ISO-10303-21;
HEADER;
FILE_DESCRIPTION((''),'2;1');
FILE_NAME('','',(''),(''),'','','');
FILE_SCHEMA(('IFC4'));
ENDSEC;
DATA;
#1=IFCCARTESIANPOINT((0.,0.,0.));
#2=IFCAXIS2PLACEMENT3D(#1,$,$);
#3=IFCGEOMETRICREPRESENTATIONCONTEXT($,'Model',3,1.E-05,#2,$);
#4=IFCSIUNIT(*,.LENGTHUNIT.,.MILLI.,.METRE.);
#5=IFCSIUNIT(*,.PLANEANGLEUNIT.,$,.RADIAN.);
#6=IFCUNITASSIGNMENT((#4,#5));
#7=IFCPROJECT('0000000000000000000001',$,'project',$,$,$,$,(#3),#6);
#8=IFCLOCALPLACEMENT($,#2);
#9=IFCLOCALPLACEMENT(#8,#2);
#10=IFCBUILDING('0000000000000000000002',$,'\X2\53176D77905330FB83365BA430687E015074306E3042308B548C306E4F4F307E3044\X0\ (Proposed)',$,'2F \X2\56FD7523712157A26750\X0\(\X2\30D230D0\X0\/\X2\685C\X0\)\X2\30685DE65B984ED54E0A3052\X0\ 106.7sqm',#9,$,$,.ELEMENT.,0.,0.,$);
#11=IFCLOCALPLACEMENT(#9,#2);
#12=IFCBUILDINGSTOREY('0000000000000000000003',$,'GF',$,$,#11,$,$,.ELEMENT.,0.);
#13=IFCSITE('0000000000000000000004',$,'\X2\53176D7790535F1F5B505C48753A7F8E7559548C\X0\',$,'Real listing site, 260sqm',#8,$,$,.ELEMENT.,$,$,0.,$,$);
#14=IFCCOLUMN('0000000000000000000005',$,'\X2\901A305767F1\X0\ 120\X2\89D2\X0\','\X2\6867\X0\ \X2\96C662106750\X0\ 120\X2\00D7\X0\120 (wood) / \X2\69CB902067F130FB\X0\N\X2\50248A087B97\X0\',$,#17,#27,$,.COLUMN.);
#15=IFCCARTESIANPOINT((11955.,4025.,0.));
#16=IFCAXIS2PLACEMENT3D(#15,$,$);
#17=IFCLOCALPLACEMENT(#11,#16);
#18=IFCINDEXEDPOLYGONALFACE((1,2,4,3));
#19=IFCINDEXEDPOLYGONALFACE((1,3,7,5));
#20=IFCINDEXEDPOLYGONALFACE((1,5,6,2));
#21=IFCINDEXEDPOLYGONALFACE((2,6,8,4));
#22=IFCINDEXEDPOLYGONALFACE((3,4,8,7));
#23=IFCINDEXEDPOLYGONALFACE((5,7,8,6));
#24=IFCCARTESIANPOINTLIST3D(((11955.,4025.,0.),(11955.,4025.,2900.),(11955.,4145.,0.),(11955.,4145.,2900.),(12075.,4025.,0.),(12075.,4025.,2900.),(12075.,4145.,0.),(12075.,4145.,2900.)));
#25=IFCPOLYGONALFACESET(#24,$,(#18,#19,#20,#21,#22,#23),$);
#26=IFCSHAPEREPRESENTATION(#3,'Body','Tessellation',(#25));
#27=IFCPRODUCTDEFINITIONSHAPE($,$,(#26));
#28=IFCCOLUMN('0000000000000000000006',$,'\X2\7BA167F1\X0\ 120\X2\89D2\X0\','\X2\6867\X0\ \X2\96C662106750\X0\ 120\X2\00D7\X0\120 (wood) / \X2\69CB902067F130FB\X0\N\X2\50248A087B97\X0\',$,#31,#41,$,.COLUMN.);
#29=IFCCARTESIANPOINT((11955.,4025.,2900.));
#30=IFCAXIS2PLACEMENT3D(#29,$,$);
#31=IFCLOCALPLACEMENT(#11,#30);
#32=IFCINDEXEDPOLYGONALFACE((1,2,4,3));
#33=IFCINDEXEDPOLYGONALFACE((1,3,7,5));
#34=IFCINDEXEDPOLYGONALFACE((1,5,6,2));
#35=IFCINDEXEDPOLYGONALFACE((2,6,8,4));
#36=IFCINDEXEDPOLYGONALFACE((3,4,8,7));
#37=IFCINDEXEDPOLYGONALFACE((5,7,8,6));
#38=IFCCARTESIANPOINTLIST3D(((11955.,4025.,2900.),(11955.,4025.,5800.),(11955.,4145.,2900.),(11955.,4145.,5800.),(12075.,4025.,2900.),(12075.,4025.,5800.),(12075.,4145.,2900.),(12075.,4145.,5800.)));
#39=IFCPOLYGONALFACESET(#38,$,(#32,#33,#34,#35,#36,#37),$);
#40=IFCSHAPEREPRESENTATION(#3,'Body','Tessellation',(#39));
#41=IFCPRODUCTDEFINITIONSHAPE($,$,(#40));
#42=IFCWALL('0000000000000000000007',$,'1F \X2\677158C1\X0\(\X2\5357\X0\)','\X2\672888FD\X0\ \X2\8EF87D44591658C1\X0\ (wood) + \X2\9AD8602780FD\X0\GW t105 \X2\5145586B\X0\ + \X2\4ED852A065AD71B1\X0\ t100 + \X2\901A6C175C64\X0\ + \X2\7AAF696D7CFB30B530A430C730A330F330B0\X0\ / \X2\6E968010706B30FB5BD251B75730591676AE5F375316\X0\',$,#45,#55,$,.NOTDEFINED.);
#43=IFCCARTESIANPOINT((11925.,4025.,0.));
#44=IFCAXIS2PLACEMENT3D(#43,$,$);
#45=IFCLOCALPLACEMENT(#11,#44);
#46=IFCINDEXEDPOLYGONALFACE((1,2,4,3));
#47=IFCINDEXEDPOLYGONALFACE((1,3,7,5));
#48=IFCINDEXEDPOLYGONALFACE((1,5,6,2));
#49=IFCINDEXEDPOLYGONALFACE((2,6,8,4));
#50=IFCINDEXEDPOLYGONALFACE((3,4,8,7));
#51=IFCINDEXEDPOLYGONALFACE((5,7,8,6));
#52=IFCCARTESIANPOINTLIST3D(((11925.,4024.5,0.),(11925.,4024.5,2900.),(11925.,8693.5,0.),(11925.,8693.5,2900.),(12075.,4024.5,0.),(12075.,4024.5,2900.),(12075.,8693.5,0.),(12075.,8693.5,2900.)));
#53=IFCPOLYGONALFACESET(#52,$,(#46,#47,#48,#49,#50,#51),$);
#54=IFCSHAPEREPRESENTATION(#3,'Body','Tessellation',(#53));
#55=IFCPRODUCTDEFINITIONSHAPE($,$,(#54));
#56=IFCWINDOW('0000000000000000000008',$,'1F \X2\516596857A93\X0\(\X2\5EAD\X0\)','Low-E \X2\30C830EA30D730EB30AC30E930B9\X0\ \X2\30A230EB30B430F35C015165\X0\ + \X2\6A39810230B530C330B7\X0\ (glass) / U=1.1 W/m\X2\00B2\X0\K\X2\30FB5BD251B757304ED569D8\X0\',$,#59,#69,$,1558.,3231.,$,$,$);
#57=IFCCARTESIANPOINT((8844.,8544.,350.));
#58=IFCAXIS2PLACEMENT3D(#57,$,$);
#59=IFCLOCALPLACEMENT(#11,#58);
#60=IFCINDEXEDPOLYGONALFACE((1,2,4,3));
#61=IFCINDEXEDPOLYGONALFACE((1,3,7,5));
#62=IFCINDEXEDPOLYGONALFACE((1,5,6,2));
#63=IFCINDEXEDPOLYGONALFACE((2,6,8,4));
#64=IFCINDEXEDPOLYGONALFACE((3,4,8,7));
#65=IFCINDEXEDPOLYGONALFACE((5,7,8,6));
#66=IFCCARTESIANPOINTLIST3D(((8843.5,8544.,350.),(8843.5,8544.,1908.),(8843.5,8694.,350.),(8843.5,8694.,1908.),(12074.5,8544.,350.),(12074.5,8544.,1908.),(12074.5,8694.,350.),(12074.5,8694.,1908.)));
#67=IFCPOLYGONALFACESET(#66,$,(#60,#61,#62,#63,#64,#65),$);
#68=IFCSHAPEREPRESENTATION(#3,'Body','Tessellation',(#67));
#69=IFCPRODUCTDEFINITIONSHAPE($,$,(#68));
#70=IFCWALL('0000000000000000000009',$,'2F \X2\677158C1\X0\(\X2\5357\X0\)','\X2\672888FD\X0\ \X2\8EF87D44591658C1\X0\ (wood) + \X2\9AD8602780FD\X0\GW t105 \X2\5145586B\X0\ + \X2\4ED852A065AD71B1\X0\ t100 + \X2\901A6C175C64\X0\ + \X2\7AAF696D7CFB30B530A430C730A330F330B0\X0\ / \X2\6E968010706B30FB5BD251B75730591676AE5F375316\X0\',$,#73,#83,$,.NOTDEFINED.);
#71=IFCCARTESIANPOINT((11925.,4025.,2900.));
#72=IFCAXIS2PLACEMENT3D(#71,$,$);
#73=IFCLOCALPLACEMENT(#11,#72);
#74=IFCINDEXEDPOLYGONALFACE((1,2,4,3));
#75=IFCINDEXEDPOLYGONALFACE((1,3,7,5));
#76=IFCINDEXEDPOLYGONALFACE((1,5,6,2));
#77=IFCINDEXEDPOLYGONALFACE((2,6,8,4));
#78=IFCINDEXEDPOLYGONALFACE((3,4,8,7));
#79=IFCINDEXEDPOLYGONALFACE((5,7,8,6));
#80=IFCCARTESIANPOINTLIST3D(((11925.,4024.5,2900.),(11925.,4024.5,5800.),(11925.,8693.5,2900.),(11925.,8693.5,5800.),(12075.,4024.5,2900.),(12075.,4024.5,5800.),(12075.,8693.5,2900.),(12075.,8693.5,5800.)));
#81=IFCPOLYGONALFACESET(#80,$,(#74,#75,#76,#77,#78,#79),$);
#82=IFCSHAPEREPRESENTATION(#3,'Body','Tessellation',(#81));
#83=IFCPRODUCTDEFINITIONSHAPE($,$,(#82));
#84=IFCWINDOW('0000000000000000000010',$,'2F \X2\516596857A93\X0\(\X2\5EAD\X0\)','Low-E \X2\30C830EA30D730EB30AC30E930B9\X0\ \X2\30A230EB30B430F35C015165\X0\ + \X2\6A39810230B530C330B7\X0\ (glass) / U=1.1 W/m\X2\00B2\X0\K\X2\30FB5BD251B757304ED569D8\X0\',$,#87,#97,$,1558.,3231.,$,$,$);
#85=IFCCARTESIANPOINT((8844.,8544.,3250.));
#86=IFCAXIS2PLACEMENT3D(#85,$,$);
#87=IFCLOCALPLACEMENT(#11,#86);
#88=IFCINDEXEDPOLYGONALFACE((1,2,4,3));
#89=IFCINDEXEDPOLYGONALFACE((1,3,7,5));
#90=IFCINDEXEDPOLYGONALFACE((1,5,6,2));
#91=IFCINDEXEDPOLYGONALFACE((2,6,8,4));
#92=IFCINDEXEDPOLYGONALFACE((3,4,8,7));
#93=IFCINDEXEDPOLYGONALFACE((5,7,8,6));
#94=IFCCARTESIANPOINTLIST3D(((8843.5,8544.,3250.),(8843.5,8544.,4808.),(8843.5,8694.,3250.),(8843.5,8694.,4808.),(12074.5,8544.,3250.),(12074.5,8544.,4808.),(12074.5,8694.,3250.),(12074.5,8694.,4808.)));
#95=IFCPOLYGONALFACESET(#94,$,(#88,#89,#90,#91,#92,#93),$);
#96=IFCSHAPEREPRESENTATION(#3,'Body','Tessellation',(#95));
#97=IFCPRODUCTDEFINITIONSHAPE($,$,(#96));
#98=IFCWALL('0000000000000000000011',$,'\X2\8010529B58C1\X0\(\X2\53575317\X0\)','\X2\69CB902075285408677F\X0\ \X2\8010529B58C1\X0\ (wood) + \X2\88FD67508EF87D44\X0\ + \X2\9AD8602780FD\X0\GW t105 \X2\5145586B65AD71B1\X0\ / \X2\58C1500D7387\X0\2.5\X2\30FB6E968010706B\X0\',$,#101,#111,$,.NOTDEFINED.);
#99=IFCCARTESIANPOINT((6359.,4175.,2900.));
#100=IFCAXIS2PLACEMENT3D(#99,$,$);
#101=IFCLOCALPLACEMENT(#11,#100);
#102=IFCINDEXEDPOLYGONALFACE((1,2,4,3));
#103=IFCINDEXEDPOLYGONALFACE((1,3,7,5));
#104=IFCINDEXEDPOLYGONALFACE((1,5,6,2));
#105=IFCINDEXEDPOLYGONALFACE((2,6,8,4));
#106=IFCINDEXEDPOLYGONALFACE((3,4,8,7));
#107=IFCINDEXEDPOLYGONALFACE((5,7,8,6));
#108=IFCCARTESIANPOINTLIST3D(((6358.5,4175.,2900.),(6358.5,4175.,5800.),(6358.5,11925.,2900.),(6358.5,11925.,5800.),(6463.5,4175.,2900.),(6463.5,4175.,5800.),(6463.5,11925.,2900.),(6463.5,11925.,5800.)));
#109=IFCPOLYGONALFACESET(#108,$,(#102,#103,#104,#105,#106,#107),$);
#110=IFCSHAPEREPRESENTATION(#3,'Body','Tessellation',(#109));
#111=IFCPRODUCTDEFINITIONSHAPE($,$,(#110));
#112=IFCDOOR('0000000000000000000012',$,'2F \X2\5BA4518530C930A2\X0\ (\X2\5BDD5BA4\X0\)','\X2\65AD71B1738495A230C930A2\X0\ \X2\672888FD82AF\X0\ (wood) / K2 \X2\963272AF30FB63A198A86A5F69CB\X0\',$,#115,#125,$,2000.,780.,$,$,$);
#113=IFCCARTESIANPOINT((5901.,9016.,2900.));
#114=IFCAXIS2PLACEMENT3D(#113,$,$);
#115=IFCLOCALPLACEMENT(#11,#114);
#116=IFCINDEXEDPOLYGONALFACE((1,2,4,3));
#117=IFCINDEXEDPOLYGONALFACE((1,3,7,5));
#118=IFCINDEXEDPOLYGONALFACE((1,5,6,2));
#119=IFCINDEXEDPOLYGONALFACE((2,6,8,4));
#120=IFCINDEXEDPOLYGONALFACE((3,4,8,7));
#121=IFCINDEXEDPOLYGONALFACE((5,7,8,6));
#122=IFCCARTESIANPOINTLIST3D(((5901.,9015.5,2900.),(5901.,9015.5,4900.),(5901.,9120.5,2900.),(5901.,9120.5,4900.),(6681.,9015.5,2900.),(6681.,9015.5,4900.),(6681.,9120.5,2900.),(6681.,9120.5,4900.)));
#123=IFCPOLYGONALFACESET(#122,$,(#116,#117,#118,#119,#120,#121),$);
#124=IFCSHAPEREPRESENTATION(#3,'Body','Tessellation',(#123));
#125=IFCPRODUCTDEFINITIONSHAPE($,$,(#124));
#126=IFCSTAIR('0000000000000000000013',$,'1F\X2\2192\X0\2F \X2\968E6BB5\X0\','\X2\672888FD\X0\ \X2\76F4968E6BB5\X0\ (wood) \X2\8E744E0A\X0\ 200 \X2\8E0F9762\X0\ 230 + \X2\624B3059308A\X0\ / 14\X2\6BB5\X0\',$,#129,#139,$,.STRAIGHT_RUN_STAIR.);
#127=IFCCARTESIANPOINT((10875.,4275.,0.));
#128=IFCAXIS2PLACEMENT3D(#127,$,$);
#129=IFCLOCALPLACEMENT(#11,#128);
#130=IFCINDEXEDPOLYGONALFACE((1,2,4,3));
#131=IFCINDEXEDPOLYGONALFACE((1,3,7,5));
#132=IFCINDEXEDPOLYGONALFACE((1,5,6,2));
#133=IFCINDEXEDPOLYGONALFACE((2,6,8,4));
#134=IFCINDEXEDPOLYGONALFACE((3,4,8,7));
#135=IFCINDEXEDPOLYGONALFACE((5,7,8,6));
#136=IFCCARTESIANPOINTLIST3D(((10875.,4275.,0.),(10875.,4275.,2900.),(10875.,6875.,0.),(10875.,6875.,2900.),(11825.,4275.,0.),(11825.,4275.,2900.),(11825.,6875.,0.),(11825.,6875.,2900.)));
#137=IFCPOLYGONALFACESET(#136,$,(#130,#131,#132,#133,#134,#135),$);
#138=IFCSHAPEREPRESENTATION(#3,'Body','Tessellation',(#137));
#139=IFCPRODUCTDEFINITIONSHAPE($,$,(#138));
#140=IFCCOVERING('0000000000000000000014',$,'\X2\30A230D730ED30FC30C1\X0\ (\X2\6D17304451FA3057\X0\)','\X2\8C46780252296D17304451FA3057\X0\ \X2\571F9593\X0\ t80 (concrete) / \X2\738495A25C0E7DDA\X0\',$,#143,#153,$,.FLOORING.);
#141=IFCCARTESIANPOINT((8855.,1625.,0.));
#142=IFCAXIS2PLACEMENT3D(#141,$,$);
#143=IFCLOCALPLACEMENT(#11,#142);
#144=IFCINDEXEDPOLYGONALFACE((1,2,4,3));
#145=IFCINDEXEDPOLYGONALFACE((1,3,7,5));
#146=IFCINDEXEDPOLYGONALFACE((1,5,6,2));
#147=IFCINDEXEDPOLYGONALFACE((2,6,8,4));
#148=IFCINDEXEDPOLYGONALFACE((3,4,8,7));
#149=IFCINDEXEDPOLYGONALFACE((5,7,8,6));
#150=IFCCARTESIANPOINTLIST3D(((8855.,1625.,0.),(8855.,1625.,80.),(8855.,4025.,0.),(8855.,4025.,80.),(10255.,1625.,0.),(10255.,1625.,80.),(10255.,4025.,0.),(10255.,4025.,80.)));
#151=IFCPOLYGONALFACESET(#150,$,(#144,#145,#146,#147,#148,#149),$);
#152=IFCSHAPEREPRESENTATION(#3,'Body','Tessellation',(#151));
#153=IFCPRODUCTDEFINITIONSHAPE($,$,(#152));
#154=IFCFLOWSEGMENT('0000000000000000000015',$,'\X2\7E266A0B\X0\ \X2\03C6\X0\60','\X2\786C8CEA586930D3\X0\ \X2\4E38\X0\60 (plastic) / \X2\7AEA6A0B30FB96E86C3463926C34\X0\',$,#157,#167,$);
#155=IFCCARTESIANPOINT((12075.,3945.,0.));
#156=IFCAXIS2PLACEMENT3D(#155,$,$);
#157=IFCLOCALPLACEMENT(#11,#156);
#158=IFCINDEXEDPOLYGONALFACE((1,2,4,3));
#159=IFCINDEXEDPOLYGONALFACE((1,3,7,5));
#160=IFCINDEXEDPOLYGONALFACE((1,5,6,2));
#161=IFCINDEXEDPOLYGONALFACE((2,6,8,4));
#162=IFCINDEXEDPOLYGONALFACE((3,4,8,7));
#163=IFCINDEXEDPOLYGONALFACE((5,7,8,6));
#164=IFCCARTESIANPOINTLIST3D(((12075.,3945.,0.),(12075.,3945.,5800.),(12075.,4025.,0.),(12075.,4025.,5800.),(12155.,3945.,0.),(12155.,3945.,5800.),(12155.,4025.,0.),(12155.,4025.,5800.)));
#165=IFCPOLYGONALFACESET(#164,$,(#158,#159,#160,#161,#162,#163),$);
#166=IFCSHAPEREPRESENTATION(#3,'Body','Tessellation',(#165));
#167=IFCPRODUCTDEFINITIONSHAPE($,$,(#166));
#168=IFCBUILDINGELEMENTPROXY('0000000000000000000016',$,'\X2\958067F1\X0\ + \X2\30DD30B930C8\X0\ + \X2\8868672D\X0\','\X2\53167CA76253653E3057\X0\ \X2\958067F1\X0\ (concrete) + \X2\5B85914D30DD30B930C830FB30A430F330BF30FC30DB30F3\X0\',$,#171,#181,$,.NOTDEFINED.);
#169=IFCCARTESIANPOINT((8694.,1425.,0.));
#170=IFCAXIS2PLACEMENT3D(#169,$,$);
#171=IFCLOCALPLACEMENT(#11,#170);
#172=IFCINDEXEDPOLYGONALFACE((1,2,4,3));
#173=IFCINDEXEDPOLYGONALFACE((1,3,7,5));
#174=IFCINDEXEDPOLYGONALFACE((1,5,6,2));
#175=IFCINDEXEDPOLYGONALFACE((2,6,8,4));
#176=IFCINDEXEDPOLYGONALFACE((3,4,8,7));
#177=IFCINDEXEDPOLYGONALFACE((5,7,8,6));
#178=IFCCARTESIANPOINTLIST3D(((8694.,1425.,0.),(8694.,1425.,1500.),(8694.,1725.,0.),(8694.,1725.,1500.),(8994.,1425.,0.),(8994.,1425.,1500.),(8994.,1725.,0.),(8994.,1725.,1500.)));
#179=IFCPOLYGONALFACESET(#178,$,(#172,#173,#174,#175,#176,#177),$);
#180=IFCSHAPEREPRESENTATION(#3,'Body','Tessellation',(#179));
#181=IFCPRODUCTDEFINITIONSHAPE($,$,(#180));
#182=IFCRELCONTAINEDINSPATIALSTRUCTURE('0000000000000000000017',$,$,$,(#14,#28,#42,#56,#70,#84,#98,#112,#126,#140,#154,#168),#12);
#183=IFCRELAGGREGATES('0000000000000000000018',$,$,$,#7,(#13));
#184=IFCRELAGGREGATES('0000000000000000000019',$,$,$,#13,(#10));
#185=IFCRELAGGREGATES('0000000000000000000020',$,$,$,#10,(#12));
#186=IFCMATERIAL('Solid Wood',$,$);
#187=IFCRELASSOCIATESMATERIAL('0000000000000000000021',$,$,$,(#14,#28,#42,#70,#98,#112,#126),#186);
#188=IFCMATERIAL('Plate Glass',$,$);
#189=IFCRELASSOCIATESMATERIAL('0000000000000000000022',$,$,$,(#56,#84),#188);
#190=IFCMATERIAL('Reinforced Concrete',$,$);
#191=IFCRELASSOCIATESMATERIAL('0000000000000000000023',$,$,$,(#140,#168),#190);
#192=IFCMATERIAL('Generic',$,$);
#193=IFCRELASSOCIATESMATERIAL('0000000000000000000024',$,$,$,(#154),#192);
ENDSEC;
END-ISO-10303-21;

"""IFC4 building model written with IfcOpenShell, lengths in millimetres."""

from ifc_helpers import new_model, si_unit, frame, frame_2d, origin, place, context, project, spatial, rectangle, extrude, material, element, fill, save


model = new_model("IFC4")

# Units and contexts
model_context = context("Model", 3, precision=1e-05, world=origin())
ifc_project = project(units=[si_unit("LENGTHUNIT", "METRE", prefix="MILLI"), si_unit("PLANEANGLEUNIT", "RADIAN")], contexts=[model_context])

# Site, building, storey
site_placement = place(None, origin())
site = spatial("IfcSite", under=ifc_project, at=site_placement, Name="北海道弟子屈町美留和", ObjectType="Real listing site, 260sqm", CompositionType="ELEMENT", RefElevation=0.0)
building_placement = place(site_placement, origin())
building = spatial("IfcBuilding", under=site, at=building_placement, Name="北海道・茶室と縁側のある和の住まい (Proposed)", ObjectType="2F 国産無垢材(ヒバ/桜)と左官仕上げ 106.7sqm", CompositionType="ELEMENT", ElevationOfRefHeight=0.0, ElevationOfTerrain=0.0)
storey_placement = place(building_placement, origin())
storey = spatial("IfcBuildingStorey", under=building, at=storey_placement, Name="GF", CompositionType="ELEMENT", Elevation=0.0)

# Columns
ifc_material_1 = material(Name="Solid Wood")
column_1_placement = place(storey_placement, frame((11955.0, 4025.0, 0.0)))
element("IfcColumn", 1, at=column_1_placement, inside=storey, material=ifc_material_1, Name="通し柱 120角", Description="桧 集成材 120×120 (wood) / 構造柱・N値計算", PredefinedType="COLUMN", context=model_context, shape_type="SweptSolid", body=[
    extrude(rectangle(XDim=120.0, YDim=120.0, at=frame_2d((60.0, 60.0))), frame((11955.0, 4025.0, 0.0)), (0.0, 0.0, 1.0), 2900.0),
])
column_2_placement = place(storey_placement, frame((11955.0, 4025.0, 2900.0)))
element("IfcColumn", 2, at=column_2_placement, inside=storey, material=ifc_material_1, Name="管柱 120角", Description="桧 集成材 120×120 (wood) / 構造柱・N値計算", PredefinedType="COLUMN", context=model_context, shape_type="SweptSolid", body=[
    extrude(rectangle(XDim=120.0, YDim=120.0, at=frame_2d((60.0, 60.0))), frame((11955.0, 4025.0, 2900.0)), (0.0, 0.0, 1.0), 2900.0),
])

# Wall, opening, window
wall_1_placement = place(storey_placement, frame((11925.0, 4025.0, 0.0)))
wall_1 = element("IfcWall", 3, at=wall_1_placement, inside=storey, material=ifc_material_1, Name="1F 東壁(南)", Description="木製 軸組外壁 (wood) + 高性能GW t105 充填 + 付加断熱 t100 + 通気層 + 窯業系サイディング / 準耐火・寒冷地外皮強化", PredefinedType="NOTDEFINED", context=model_context, shape_type="SweptSolid", body=[
    extrude(rectangle(XDim=150.0, YDim=4669.0, at=frame_2d((75.0, 2334.0))), frame((11925.0, 4025.0, 0.0)), (0.0, 0.0, 1.0), 2900.0),
])
opening_1_placement = place(storey_placement, frame((8844.0, 8544.0, 350.0)))
opening_1 = element("IfcOpeningElement", 4, at=opening_1_placement, cuts=wall_1, PredefinedType="NOTDEFINED", context=model_context, shape_type="SweptSolid", body=[
    extrude(rectangle(XDim=3231.0, YDim=150.0, at=frame_2d((1615.0, 75.0))), frame((8844.0, 8544.0, 350.0)), (0.0, 0.0, 1.0), 1558.0),
])
ifc_material_2 = material(Name="Plate Glass")
window_1_placement = place(storey_placement, frame((8844.0, 8544.0, 350.0)))
window_1 = element("IfcWindow", 5, at=window_1_placement, inside=storey, material=ifc_material_2, Name="1F 入隅窓(庭)", Description="Low-E トリプルガラス アルゴン封入 + 樹脂サッシ (glass) / U=1.1 W/m²K・寒冷地仕様", OverallHeight=1558.0, OverallWidth=3231.0, context=model_context, shape_type="SweptSolid", body=[
    extrude(rectangle(XDim=3231.0, YDim=150.0, at=frame_2d((1615.0, 75.0))), frame((8844.0, 8544.0, 350.0)), (0.0, 0.0, 1.0), 1558.0),
])
fill(opening_1, window_1)

# Wall, opening, window
wall_2_placement = place(storey_placement, frame((11925.0, 4025.0, 2900.0)))
wall_2 = element("IfcWall", 6, at=wall_2_placement, inside=storey, material=ifc_material_1, Name="2F 東壁(南)", Description="木製 軸組外壁 (wood) + 高性能GW t105 充填 + 付加断熱 t100 + 通気層 + 窯業系サイディング / 準耐火・寒冷地外皮強化", PredefinedType="NOTDEFINED", context=model_context, shape_type="SweptSolid", body=[
    extrude(rectangle(XDim=150.0, YDim=4669.0, at=frame_2d((75.0, 2334.0))), frame((11925.0, 4025.0, 2900.0)), (0.0, 0.0, 1.0), 2900.0),
])
opening_2_placement = place(storey_placement, frame((8844.0, 8544.0, 3250.0)))
opening_2 = element("IfcOpeningElement", 7, at=opening_2_placement, cuts=wall_2, PredefinedType="NOTDEFINED", context=model_context, shape_type="SweptSolid", body=[
    extrude(rectangle(XDim=3231.0, YDim=150.0, at=frame_2d((1615.0, 75.0))), frame((8844.0, 8544.0, 3250.0)), (0.0, 0.0, 1.0), 1558.0),
])
window_2_placement = place(storey_placement, frame((8844.0, 8544.0, 3250.0)))
window_2 = element("IfcWindow", 8, at=window_2_placement, inside=storey, material=ifc_material_2, Name="2F 入隅窓(庭)", Description="Low-E トリプルガラス アルゴン封入 + 樹脂サッシ (glass) / U=1.1 W/m²K・寒冷地仕様", OverallHeight=1558.0, OverallWidth=3231.0, context=model_context, shape_type="SweptSolid", body=[
    extrude(rectangle(XDim=3231.0, YDim=150.0, at=frame_2d((1615.0, 75.0))), frame((8844.0, 8544.0, 3250.0)), (0.0, 0.0, 1.0), 1558.0),
])
fill(opening_2, window_2)

# Wall, opening, door
wall_3_placement = place(storey_placement, frame((6359.0, 4175.0, 2900.0)))
wall_3 = element("IfcWall", 9, at=wall_3_placement, inside=storey, material=ifc_material_1, Name="耐力壁(南北)", Description="構造用合板 耐力壁 (wood) + 製材軸組 + 高性能GW t105 充填断熱 / 壁倍率2.5・準耐火", PredefinedType="NOTDEFINED", context=model_context, shape_type="SweptSolid", body=[
    extrude(rectangle(XDim=105.0, YDim=7750.0, at=frame_2d((52.0, 3875.0))), frame((6359.0, 4175.0, 2900.0)), (0.0, 0.0, 1.0), 2900.0),
])
opening_3_placement = place(storey_placement, frame((5901.0, 9016.0, 2900.0)))
opening_3 = element("IfcOpeningElement", 10, at=opening_3_placement, cuts=wall_3, PredefinedType="NOTDEFINED", context=model_context, shape_type="SweptSolid", body=[
    extrude(rectangle(XDim=780.0, YDim=105.0, at=frame_2d((390.0, 52.0))), frame((5901.0, 9016.0, 2900.0)), (0.0, 0.0, 1.0), 2000.0),
])
door_placement = place(storey_placement, frame((5901.0, 9016.0, 2900.0)))
door = element("IfcDoor", 11, at=door_placement, inside=storey, material=ifc_material_1, Name="2F 室内ドア (寝室)", Description="断熱玄関ドア 木製芯 (wood) / K2 防犯・採風機構", OverallHeight=2000.0, OverallWidth=780.0, context=model_context, shape_type="SweptSolid", body=[
    extrude(rectangle(XDim=780.0, YDim=105.0, at=frame_2d((390.0, 52.0))), frame((5901.0, 9016.0, 2900.0)), (0.0, 0.0, 1.0), 2000.0),
])
fill(opening_3, door)

# Stair
stair_placement = place(storey_placement, frame((10875.0, 4275.0, 0.0)))
element("IfcStair", 12, at=stair_placement, inside=storey, material=ifc_material_1, Name="1F→2F 階段", Description="木製 直階段 (wood) 蹴上 200 踏面 230 + 手すり / 14段", PredefinedType="STRAIGHT_RUN_STAIR", context=model_context, shape_type="SweptSolid", body=[
    extrude(rectangle(XDim=950.0, YDim=2600.0, at=frame_2d((475.0, 1300.0))), frame((10875.0, 4275.0, 0.0)), (0.0, 0.0, 1.0), 2900.0),
])

# Covering
ifc_material_3 = material(Name="Reinforced Concrete")
covering_placement = place(storey_placement, frame((8855.0, 1625.0, 0.0)))
element("IfcCovering", 13, at=covering_placement, inside=storey, material=ifc_material_3, Name="アプローチ (洗い出し)", Description="豆砂利洗い出し 土間 t80 (concrete) / 玄関導線", PredefinedType="FLOORING", context=model_context, shape_type="SweptSolid", body=[
    extrude(rectangle(XDim=1400.0, YDim=2400.0, at=frame_2d((700.0, 1200.0))), frame((8855.0, 1625.0, 0.0)), (0.0, 0.0, 1.0), 80.0),
])

# Flow segment
ifc_material_4 = material(Name="Generic")
flow_segment_placement = place(storey_placement, frame((12075.0, 3945.0, 0.0)))
element("IfcFlowSegment", 14, at=flow_segment_placement, inside=storey, material=ifc_material_4, Name="縦樋 φ60", Description="硬質塩ビ 丸60 (plastic) / 竪樋・雨水排水", context=model_context, shape_type="SweptSolid", body=[
    extrude(rectangle(XDim=80.0, YDim=80.0, at=frame_2d((40.0, 40.0))), frame((12075.0, 3945.0, 0.0)), (0.0, 0.0, 1.0), 5800.0),
])

# Building element proxy
proxy_placement = place(storey_placement, frame((8694.0, 1425.0, 0.0)))
element("IfcBuildingElementProxy", 15, at=proxy_placement, inside=storey, material=ifc_material_3, Name="門柱 + ポスト + 表札", Description="化粧打放し 門柱 (concrete) + 宅配ポスト・インターホン", PredefinedType="NOTDEFINED", context=model_context, shape_type="SweptSolid", body=[
    extrude(rectangle(XDim=300.0, YDim=300.0, at=frame_2d((150.0, 150.0))), frame((8694.0, 1425.0, 0.0)), (0.0, 0.0, 1.0), 1500.0),
])

save(model, "model.ifc")
